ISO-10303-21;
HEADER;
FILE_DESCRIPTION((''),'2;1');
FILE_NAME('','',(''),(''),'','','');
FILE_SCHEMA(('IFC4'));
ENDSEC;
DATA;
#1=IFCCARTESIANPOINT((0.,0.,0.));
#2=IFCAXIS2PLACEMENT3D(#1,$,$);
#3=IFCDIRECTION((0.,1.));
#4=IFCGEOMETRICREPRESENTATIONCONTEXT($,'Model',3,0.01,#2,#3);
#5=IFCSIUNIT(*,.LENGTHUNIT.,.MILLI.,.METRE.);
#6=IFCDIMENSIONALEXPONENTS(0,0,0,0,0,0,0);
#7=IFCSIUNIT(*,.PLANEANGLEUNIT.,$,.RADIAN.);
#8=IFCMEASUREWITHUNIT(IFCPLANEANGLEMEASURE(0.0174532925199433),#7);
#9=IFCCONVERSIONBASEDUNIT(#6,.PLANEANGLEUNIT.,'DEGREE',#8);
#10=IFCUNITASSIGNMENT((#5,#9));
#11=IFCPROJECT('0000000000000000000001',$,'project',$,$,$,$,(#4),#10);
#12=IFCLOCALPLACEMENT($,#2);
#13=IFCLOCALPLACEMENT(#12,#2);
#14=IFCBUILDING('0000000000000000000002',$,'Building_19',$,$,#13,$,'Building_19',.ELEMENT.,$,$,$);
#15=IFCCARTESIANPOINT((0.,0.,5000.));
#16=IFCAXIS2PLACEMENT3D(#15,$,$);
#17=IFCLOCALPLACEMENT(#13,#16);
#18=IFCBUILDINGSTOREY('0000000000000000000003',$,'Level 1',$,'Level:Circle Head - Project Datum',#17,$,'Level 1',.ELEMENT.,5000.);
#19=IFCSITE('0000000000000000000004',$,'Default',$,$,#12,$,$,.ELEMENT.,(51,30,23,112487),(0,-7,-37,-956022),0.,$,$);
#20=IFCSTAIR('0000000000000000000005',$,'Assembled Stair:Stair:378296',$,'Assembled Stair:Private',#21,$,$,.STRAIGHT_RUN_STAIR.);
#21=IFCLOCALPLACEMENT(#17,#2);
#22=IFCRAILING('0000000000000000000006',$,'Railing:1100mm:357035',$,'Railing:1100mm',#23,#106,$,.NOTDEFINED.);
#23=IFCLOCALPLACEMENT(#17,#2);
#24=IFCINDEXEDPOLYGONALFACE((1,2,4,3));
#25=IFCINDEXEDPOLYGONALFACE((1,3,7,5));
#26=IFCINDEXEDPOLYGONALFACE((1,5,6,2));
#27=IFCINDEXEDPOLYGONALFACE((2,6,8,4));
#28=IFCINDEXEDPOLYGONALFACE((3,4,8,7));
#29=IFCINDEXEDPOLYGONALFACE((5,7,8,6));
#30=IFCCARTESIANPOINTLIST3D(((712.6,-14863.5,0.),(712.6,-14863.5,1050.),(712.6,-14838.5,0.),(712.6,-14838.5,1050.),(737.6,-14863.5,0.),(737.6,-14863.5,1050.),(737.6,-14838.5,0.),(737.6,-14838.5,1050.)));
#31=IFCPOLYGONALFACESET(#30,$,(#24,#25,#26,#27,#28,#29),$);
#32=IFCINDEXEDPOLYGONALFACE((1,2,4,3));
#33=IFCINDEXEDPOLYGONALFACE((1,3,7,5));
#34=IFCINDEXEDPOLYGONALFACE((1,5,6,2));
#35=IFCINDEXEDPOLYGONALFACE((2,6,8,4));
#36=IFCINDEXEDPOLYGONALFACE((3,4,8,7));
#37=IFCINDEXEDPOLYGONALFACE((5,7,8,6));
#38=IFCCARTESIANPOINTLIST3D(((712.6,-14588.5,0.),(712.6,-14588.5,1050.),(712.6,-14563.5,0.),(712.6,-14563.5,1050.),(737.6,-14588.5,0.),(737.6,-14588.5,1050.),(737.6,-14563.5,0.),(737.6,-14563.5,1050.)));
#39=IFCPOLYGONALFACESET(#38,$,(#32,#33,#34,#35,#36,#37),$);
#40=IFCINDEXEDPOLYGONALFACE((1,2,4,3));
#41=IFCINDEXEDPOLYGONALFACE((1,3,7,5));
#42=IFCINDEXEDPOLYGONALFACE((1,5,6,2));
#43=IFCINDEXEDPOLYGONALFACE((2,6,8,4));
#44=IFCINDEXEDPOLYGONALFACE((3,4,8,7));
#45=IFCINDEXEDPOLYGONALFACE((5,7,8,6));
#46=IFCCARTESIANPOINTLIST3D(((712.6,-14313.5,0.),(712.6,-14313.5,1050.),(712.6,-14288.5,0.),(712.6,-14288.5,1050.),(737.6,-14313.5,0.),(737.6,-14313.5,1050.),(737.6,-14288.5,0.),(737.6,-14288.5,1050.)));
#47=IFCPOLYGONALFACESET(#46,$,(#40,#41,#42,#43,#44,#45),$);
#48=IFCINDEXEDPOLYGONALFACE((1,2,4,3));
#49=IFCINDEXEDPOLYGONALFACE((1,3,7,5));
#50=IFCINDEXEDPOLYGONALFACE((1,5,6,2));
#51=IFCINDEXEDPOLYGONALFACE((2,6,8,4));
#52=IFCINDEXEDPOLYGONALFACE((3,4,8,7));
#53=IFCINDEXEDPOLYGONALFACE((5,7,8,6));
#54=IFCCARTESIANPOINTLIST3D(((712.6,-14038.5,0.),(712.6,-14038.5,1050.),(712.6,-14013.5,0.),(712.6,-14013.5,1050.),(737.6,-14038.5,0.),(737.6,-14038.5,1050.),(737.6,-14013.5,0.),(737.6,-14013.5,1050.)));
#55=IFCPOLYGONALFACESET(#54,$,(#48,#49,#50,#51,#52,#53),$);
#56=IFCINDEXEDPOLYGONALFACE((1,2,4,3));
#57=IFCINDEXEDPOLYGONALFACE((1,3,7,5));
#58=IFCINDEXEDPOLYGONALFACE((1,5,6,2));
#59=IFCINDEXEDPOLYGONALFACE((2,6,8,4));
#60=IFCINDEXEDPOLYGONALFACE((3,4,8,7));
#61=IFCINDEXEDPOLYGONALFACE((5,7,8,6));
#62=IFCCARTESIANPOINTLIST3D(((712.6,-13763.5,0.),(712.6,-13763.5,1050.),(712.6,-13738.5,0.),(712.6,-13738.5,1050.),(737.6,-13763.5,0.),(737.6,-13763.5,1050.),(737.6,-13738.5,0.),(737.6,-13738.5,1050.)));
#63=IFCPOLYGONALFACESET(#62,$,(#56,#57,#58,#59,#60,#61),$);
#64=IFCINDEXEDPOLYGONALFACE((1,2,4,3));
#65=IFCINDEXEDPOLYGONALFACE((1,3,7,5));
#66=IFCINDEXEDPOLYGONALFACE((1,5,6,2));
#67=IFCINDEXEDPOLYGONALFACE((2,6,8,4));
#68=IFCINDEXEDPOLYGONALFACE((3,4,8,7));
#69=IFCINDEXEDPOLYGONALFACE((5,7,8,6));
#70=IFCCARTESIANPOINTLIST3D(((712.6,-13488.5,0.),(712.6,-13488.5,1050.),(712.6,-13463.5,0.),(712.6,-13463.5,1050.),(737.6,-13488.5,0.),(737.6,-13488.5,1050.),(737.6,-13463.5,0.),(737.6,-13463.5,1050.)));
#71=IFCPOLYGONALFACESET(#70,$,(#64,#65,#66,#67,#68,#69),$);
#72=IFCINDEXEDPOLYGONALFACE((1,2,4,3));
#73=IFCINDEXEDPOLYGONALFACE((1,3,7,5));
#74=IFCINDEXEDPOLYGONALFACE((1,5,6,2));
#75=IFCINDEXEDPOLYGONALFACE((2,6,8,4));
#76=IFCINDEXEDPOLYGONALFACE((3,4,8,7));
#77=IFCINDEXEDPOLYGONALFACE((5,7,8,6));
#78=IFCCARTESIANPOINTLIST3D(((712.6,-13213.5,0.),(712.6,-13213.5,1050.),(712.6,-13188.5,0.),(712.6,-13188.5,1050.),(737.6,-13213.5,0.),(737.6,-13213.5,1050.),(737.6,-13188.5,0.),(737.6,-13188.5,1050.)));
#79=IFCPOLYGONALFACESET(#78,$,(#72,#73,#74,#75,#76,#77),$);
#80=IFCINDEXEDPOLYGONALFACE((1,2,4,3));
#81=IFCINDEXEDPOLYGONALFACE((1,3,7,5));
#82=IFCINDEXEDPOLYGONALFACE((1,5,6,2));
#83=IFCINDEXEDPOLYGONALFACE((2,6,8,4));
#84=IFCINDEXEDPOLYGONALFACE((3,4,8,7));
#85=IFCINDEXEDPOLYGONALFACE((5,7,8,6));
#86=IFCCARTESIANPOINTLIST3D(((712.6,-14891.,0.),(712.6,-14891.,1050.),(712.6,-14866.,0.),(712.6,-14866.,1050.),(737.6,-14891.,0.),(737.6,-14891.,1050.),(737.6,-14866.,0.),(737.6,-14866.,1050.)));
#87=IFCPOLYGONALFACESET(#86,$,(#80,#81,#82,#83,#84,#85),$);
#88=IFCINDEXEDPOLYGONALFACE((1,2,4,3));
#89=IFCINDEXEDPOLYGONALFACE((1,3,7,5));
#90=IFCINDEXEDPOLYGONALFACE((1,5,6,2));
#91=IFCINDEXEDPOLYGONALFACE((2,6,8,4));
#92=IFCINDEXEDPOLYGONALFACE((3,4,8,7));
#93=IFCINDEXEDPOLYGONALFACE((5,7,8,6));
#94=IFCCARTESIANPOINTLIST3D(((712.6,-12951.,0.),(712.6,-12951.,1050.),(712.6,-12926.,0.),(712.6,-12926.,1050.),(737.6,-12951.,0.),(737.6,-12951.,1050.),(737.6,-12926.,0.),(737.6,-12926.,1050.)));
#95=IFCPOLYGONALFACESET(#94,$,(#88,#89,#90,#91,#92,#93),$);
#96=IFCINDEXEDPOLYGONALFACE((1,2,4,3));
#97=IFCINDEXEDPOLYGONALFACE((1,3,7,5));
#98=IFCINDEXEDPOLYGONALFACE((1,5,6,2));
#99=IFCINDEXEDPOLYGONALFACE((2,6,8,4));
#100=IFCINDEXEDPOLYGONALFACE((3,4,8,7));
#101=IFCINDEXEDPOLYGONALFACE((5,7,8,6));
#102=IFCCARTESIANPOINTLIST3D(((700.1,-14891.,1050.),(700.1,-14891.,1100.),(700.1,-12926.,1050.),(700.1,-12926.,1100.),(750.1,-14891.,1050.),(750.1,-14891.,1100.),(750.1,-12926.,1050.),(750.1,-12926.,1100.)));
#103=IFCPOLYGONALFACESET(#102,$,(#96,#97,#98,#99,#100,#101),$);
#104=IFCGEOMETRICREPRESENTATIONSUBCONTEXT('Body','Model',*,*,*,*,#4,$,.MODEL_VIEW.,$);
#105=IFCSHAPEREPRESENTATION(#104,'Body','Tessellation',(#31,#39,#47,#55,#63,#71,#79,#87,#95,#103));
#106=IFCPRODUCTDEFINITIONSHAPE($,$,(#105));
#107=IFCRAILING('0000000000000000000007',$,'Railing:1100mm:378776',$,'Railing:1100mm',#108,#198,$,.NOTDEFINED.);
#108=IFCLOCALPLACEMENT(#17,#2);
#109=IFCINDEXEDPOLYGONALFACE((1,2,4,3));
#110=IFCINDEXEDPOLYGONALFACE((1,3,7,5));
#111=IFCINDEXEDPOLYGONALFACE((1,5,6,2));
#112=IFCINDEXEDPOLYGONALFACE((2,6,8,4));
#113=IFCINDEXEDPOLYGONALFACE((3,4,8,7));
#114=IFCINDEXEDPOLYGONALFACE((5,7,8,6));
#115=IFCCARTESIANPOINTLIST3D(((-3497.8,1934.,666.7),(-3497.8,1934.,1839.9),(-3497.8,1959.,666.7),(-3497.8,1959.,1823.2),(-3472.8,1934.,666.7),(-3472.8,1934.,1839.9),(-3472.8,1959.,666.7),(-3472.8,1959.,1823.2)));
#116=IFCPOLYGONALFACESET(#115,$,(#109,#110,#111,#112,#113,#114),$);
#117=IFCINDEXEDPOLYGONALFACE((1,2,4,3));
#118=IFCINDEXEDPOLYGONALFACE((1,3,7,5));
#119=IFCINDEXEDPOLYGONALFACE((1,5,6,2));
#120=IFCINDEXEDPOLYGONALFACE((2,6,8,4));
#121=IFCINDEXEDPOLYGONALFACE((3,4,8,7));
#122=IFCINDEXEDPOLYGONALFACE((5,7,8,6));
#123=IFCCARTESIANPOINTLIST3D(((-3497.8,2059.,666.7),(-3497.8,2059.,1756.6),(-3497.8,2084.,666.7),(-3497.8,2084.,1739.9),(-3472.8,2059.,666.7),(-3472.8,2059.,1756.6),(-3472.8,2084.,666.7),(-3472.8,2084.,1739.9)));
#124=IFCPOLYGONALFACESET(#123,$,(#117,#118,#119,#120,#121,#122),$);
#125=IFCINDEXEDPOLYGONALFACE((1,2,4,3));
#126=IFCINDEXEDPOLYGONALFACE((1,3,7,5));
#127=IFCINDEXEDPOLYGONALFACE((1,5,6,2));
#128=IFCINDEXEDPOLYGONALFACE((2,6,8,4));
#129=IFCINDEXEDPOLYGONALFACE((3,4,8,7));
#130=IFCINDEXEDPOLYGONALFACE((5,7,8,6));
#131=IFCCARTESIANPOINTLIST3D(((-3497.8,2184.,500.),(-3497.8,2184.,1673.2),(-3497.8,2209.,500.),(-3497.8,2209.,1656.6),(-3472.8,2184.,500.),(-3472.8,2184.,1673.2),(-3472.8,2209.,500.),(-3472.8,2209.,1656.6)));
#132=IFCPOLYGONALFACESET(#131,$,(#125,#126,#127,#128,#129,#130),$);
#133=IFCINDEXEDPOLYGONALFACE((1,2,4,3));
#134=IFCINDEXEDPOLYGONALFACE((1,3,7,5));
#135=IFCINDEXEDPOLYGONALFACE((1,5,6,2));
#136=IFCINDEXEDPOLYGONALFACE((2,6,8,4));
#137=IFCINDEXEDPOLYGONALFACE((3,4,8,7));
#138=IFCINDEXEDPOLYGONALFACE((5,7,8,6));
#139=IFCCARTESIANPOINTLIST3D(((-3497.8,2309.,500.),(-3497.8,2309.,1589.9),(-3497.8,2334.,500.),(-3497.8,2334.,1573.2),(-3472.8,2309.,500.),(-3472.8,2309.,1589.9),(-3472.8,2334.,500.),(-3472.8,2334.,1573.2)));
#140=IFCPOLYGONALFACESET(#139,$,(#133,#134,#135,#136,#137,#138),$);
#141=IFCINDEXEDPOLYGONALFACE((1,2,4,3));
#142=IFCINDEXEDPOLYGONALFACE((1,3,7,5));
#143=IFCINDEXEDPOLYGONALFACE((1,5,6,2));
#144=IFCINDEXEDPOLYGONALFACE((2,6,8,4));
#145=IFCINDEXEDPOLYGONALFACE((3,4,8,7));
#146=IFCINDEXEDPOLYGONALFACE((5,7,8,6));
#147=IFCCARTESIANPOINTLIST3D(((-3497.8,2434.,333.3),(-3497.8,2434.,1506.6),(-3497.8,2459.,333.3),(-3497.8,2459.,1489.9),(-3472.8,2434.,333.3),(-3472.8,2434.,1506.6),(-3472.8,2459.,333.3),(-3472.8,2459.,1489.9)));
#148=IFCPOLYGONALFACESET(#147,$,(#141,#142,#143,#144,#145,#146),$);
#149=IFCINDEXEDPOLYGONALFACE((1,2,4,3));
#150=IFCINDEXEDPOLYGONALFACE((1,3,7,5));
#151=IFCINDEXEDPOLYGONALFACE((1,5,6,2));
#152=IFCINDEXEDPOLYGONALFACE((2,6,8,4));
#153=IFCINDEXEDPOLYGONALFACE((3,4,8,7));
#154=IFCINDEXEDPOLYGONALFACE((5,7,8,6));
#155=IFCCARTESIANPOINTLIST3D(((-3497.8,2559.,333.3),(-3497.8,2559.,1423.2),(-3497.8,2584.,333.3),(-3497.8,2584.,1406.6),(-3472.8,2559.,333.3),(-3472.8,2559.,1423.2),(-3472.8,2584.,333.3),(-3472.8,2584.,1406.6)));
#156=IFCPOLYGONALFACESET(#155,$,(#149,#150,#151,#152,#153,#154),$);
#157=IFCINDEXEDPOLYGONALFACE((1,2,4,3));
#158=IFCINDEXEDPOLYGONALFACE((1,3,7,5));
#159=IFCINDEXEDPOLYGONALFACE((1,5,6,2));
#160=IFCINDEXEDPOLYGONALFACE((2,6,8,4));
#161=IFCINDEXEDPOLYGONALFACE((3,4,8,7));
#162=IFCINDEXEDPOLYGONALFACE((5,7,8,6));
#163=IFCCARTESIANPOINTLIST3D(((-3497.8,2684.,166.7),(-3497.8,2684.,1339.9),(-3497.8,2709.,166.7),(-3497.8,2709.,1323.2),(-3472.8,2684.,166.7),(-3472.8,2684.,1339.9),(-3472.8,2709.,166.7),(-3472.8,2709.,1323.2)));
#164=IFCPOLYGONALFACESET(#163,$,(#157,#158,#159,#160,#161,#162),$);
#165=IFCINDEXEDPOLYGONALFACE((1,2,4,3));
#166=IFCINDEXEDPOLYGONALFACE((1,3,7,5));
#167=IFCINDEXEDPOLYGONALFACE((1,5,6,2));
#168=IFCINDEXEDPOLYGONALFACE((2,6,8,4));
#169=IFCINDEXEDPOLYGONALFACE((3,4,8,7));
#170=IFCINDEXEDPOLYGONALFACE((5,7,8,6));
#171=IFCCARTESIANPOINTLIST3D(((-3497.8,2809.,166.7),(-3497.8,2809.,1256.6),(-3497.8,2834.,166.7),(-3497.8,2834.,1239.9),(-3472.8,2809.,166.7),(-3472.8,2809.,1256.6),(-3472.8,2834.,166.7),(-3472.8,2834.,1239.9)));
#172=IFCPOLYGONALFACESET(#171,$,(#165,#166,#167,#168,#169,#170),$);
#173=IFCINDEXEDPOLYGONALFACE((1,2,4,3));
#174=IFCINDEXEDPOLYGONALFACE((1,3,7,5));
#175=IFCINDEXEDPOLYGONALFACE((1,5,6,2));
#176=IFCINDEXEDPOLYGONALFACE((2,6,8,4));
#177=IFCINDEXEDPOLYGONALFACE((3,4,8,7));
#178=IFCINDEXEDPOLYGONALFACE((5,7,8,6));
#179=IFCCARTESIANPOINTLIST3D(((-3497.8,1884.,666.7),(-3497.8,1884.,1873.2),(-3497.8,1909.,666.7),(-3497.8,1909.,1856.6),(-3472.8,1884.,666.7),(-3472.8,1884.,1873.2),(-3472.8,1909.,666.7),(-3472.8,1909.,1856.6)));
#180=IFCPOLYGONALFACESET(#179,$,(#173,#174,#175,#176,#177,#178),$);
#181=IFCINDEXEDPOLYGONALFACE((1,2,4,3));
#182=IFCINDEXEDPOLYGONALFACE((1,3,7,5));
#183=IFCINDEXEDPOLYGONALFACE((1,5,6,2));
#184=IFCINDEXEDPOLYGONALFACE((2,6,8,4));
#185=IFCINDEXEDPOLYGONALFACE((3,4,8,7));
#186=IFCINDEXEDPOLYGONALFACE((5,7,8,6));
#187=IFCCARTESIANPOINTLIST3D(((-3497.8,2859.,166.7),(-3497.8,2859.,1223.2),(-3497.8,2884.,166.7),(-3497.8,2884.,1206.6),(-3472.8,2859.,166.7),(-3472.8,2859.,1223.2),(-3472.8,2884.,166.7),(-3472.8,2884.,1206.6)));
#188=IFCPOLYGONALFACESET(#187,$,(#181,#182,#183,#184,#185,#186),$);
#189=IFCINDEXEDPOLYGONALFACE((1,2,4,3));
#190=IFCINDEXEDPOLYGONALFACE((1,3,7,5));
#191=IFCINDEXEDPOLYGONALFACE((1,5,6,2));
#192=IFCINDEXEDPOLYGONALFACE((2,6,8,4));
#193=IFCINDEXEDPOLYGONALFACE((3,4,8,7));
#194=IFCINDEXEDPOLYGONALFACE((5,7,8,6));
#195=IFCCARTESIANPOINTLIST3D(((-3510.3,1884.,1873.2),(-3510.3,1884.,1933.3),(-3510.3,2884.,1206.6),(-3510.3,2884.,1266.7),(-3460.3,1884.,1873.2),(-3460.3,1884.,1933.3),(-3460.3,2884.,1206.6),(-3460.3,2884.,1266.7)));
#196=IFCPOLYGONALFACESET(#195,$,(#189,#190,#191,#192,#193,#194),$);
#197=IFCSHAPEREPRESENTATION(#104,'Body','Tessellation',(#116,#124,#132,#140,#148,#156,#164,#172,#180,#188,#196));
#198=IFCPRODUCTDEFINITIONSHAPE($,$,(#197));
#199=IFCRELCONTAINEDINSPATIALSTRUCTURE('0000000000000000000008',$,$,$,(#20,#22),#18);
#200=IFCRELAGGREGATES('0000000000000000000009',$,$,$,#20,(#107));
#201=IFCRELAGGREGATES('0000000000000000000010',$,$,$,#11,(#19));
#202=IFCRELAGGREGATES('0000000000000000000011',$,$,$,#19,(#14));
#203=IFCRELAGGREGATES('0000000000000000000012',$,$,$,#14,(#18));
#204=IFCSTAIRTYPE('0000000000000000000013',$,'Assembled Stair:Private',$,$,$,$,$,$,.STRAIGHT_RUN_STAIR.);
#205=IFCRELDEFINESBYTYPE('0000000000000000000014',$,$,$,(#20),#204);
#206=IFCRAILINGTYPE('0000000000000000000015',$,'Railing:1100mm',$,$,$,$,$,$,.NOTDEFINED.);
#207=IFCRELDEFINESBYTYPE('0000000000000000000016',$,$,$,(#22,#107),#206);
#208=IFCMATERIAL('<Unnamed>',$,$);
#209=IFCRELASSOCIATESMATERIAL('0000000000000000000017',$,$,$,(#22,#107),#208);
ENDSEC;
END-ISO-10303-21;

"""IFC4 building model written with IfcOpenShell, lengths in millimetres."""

from ifc_helpers import new_model, entity, si_unit, converted_unit, direction, frame, origin, place, context, subcontext, project, spatial, indexed_curve, outline, extrude, material, type_object, element, aggregate, save


model = new_model("IFC4")

# Units and contexts
model_context = context("Model", 3, precision=0.01, world=origin(), true_north=direction((0.0, 1.0)))
body_context = subcontext(model_context, "Body", "Model", "MODEL_VIEW")
ifc_project = project(units=[si_unit("LENGTHUNIT", "METRE", prefix="MILLI"), converted_unit("PLANEANGLEUNIT", "DEGREE", entity("IfcPlaneAngleMeasure", 0.0174532925199433), si_unit("PLANEANGLEUNIT", "RADIAN"), dimensions=[0, 0, 0, 0, 0, 0, 0])], contexts=[model_context])

# Site, building, storey
site_placement = place(None, origin())
site = spatial("IfcSite", under=ifc_project, at=site_placement, Name="Default", CompositionType="ELEMENT", RefLatitude=(51, 30, 23, 112487), RefLongitude=(0, -7, -37, -956022), RefElevation=0.0)
building_placement = place(site_placement, origin())
building = spatial("IfcBuilding", under=site, at=building_placement, Name="Building_19", LongName="Building_19", CompositionType="ELEMENT")
storey_placement = place(building_placement, frame((0.0, 0.0, 5000.0)))
storey = spatial("IfcBuildingStorey", under=building, at=storey_placement, Name="Level 1", ObjectType="Level:Circle Head - Project Datum", LongName="Level 1", CompositionType="ELEMENT", Elevation=5000.0)

# Stair
stair_type = type_object("IfcStairType", Name="Assembled Stair:Private", PredefinedType="STRAIGHT_RUN_STAIR")
ifc_material_1 = material(Name="<Unnamed>")
stair_1_placement = place(storey_placement, origin())
stair_1 = element("IfcStair", 1, at=stair_1_placement, inside=storey, type_object=stair_type, Name="Assembled Stair:Stair:378296", ObjectType="Assembled Stair:Private", PredefinedType="STRAIGHT_RUN_STAIR")

# Railings
railing_type = type_object("IfcRailingType", Name="Railing:1100mm", PredefinedType="NOTDEFINED")
railing_1_placement = place(storey_placement, origin())
element("IfcRailing", 2, at=railing_1_placement, inside=storey, type_object=railing_type, material=ifc_material_1, Name="Railing:1100mm:357035", ObjectType="Railing:1100mm", PredefinedType="NOTDEFINED", context=body_context, shape_type="SweptSolid", body=[
    extrude(outline(indexed_curve([(-12.5, -12.5), (12.5, -12.5), (12.5, 12.5), (-12.5, 12.5), (-12.5, -12.5)], self_intersect=False)), frame((725.1, -14851.0, 0.0), z_axis=(0.0, 0.0, 1.0), x_axis=(0.0, -1.0, 0.0)), (0.0, 0.0, 1.0), 1050.0),
    extrude(outline(indexed_curve([(-12.5, -12.5), (12.5, -12.5), (12.5, 12.5), (-12.5, 12.5), (-12.5, -12.5)], self_intersect=False)), frame((725.1, -14576.0, 0.0), z_axis=(0.0, 0.0, 1.0), x_axis=(0.0, -1.0, 0.0)), (0.0, 0.0, 1.0), 1050.0),
    extrude(outline(indexed_curve([(-12.5, -12.5), (12.5, -12.5), (12.5, 12.5), (-12.5, 12.5), (-12.5, -12.5)], self_intersect=False)), frame((725.1, -14301.0, 0.0), z_axis=(0.0, 0.0, 1.0), x_axis=(0.0, -1.0, 0.0)), (0.0, 0.0, 1.0), 1050.0),
    extrude(outline(indexed_curve([(-12.5, -12.5), (12.5, -12.5), (12.5, 12.5), (-12.5, 12.5), (-12.5, -12.5)], self_intersect=False)), frame((725.1, -14026.0, 0.0), z_axis=(0.0, 0.0, 1.0), x_axis=(0.0, -1.0, 0.0)), (0.0, 0.0, 1.0), 1050.0),
    extrude(outline(indexed_curve([(-12.5, -12.5), (12.5, -12.5), (12.5, 12.5), (-12.5, 12.5), (-12.5, -12.5)], self_intersect=False)), frame((725.1, -13751.0, 0.0), z_axis=(0.0, 0.0, 1.0), x_axis=(0.0, -1.0, 0.0)), (0.0, 0.0, 1.0), 1050.0),
    extrude(outline(indexed_curve([(-12.5, -12.5), (12.5, -12.5), (12.5, 12.5), (-12.5, 12.5), (-12.5, -12.5)], self_intersect=False)), frame((725.1, -13476.0, 0.0), z_axis=(0.0, 0.0, 1.0), x_axis=(0.0, -1.0, 0.0)), (0.0, 0.0, 1.0), 1050.0),
    extrude(outline(indexed_curve([(-12.5, -12.5), (12.5, -12.5), (12.5, 12.5), (-12.5, 12.5), (-12.5, -12.5)], self_intersect=False)), frame((725.1, -13201.0, 0.0), z_axis=(0.0, 0.0, 1.0), x_axis=(0.0, -1.0, 0.0)), (0.0, 0.0, 1.0), 1050.0),
    extrude(outline(indexed_curve([(-12.5, -12.5), (12.5, -12.5), (12.5, 12.5), (-12.5, 12.5), (-12.5, -12.5)], self_intersect=False)), frame((725.1, -14878.5, 0.0), z_axis=(0.0, 0.0, 1.0), x_axis=(0.0, -1.0, 0.0)), (0.0, 0.0, 1.0), 1050.0),
    extrude(outline(indexed_curve([(-12.5, -12.5), (12.5, -12.5), (12.5, 12.5), (-12.5, 12.5), (-12.5, -12.5)], self_intersect=False)), frame((725.1, -12938.5, 0.0), z_axis=(0.0, 0.0, 1.0), x_axis=(0.0, -1.0, 0.0)), (0.0, 0.0, 1.0), 1050.0),
    extrude(outline(indexed_curve([(-982.5, -25.0), (982.5, -25.0), (982.5, 25.0), (-982.5, 25.0), (-982.5, -25.0)], self_intersect=False)), frame((725.1, -13908.5, 1050.0), z_axis=(0.0, 0.0, 1.0), x_axis=(0.0, -1.0, 0.0)), (0.0, 0.0, 1.0), 50.0),
])
railing_2_placement = place(stair_1_placement, origin())
railing_2 = element("IfcRailing", 3, at=railing_2_placement, type_object=railing_type, material=ifc_material_1, Name="Railing:1100mm:378776", ObjectType="Railing:1100mm", PredefinedType="NOTDEFINED", context=body_context, shape_type="SweptSolid", body=[
    extrude(outline(indexed_curve([(-582.5, -12.5), (574.1, -12.5), (590.8, 12.5), (-582.5, 12.5), (-582.5, -12.5)], self_intersect=False)), frame((-3497.8, 1946.5, 1249.1), z_axis=(1.0, 0.0, 0.0), x_axis=(0.0, 0.0, 1.0)), (0.0, 0.0, 1.0), 25.0),
    extrude(outline(indexed_curve([(-540.8, -12.5), (532.5, -12.5), (549.1, 12.5), (-540.8, 12.5), (-540.8, -12.5)], self_intersect=False)), frame((-3497.8, 2071.5, 1207.5), z_axis=(1.0, 0.0, 0.0), x_axis=(0.0, 0.0, 1.0)), (0.0, 0.0, 1.0), 25.0),
    extrude(outline(indexed_curve([(-582.5, -12.5), (574.1, -12.5), (590.8, 12.5), (-582.5, 12.5), (-582.5, -12.5)], self_intersect=False)), frame((-3497.8, 2196.5, 1082.5), z_axis=(1.0, 0.0, 0.0), x_axis=(0.0, 0.0, 1.0)), (0.0, 0.0, 1.0), 25.0),
    extrude(outline(indexed_curve([(-540.8, -12.5), (532.5, -12.5), (549.1, 12.5), (-540.8, 12.5), (-540.8, -12.5)], self_intersect=False)), frame((-3497.8, 2321.5, 1040.8), z_axis=(1.0, 0.0, 0.0), x_axis=(0.0, 0.0, 1.0)), (0.0, 0.0, 1.0), 25.0),
    extrude(outline(indexed_curve([(-582.5, -12.5), (574.1, -12.5), (590.8, 12.5), (-582.5, 12.5), (-582.5, -12.5)], self_intersect=False)), frame((-3497.8, 2446.5, 915.8), z_axis=(1.0, 0.0, 0.0), x_axis=(0.0, 0.0, 1.0)), (0.0, 0.0, 1.0), 25.0),
    extrude(outline(indexed_curve([(-540.8, -12.5), (532.5, -12.5), (549.1, 12.5), (-540.8, 12.5), (-540.8, -12.5)], self_intersect=False)), frame((-3497.8, 2571.5, 874.1), z_axis=(1.0, 0.0, 0.0), x_axis=(0.0, 0.0, 1.0)), (0.0, 0.0, 1.0), 25.0),
    extrude(outline(indexed_curve([(-582.5, -12.5), (574.1, -12.5), (590.8, 12.5), (-582.5, 12.5), (-582.5, -12.5)], self_intersect=False)), frame((-3497.8, 2696.5, 749.1), z_axis=(1.0, 0.0, 0.0), x_axis=(0.0, 0.0, 1.0)), (0.0, 0.0, 1.0), 25.0),
    extrude(outline(indexed_curve([(-540.8, -12.5), (532.5, -12.5), (549.1, 12.5), (-540.8, 12.5), (-540.8, -12.5)], self_intersect=False)), frame((-3497.8, 2821.5, 707.5), z_axis=(1.0, 0.0, 0.0), x_axis=(0.0, 0.0, 1.0)), (0.0, 0.0, 1.0), 25.0),
    extrude(outline(indexed_curve([(-599.1, -12.5), (590.8, -12.5), (607.5, 12.5), (-599.1, 12.5), (-599.1, -12.5)], self_intersect=False)), frame((-3497.8, 1896.5, 1265.8), z_axis=(1.0, 0.0, 0.0), x_axis=(0.0, 0.0, 1.0)), (0.0, 0.0, 1.0), 25.0),
    extrude(outline(indexed_curve([(-524.1, -12.5), (515.8, -12.5), (532.5, 12.5), (-524.1, 12.5), (-524.1, -12.5)], self_intersect=False)), frame((-3497.8, 2871.5, 690.8), z_axis=(1.0, 0.0, 0.0), x_axis=(0.0, 0.0, 1.0)), (0.0, 0.0, 1.0), 25.0),
    extrude(outline(indexed_curve([(-584.3, -25.0), (617.6, -25.0), (584.3, 25.0), (-617.6, 25.0), (-584.3, -25.0)], self_intersect=False)), frame((-3510.3, 2384.0, 1570.0), z_axis=(1.0, 0.0, 0.0), x_axis=(0.0, -0.83205, 0.5547)), (0.0, 0.0, 1.0), 50.0),
])
aggregate(stair_1, [railing_2])

save(model, "model.ifc")
